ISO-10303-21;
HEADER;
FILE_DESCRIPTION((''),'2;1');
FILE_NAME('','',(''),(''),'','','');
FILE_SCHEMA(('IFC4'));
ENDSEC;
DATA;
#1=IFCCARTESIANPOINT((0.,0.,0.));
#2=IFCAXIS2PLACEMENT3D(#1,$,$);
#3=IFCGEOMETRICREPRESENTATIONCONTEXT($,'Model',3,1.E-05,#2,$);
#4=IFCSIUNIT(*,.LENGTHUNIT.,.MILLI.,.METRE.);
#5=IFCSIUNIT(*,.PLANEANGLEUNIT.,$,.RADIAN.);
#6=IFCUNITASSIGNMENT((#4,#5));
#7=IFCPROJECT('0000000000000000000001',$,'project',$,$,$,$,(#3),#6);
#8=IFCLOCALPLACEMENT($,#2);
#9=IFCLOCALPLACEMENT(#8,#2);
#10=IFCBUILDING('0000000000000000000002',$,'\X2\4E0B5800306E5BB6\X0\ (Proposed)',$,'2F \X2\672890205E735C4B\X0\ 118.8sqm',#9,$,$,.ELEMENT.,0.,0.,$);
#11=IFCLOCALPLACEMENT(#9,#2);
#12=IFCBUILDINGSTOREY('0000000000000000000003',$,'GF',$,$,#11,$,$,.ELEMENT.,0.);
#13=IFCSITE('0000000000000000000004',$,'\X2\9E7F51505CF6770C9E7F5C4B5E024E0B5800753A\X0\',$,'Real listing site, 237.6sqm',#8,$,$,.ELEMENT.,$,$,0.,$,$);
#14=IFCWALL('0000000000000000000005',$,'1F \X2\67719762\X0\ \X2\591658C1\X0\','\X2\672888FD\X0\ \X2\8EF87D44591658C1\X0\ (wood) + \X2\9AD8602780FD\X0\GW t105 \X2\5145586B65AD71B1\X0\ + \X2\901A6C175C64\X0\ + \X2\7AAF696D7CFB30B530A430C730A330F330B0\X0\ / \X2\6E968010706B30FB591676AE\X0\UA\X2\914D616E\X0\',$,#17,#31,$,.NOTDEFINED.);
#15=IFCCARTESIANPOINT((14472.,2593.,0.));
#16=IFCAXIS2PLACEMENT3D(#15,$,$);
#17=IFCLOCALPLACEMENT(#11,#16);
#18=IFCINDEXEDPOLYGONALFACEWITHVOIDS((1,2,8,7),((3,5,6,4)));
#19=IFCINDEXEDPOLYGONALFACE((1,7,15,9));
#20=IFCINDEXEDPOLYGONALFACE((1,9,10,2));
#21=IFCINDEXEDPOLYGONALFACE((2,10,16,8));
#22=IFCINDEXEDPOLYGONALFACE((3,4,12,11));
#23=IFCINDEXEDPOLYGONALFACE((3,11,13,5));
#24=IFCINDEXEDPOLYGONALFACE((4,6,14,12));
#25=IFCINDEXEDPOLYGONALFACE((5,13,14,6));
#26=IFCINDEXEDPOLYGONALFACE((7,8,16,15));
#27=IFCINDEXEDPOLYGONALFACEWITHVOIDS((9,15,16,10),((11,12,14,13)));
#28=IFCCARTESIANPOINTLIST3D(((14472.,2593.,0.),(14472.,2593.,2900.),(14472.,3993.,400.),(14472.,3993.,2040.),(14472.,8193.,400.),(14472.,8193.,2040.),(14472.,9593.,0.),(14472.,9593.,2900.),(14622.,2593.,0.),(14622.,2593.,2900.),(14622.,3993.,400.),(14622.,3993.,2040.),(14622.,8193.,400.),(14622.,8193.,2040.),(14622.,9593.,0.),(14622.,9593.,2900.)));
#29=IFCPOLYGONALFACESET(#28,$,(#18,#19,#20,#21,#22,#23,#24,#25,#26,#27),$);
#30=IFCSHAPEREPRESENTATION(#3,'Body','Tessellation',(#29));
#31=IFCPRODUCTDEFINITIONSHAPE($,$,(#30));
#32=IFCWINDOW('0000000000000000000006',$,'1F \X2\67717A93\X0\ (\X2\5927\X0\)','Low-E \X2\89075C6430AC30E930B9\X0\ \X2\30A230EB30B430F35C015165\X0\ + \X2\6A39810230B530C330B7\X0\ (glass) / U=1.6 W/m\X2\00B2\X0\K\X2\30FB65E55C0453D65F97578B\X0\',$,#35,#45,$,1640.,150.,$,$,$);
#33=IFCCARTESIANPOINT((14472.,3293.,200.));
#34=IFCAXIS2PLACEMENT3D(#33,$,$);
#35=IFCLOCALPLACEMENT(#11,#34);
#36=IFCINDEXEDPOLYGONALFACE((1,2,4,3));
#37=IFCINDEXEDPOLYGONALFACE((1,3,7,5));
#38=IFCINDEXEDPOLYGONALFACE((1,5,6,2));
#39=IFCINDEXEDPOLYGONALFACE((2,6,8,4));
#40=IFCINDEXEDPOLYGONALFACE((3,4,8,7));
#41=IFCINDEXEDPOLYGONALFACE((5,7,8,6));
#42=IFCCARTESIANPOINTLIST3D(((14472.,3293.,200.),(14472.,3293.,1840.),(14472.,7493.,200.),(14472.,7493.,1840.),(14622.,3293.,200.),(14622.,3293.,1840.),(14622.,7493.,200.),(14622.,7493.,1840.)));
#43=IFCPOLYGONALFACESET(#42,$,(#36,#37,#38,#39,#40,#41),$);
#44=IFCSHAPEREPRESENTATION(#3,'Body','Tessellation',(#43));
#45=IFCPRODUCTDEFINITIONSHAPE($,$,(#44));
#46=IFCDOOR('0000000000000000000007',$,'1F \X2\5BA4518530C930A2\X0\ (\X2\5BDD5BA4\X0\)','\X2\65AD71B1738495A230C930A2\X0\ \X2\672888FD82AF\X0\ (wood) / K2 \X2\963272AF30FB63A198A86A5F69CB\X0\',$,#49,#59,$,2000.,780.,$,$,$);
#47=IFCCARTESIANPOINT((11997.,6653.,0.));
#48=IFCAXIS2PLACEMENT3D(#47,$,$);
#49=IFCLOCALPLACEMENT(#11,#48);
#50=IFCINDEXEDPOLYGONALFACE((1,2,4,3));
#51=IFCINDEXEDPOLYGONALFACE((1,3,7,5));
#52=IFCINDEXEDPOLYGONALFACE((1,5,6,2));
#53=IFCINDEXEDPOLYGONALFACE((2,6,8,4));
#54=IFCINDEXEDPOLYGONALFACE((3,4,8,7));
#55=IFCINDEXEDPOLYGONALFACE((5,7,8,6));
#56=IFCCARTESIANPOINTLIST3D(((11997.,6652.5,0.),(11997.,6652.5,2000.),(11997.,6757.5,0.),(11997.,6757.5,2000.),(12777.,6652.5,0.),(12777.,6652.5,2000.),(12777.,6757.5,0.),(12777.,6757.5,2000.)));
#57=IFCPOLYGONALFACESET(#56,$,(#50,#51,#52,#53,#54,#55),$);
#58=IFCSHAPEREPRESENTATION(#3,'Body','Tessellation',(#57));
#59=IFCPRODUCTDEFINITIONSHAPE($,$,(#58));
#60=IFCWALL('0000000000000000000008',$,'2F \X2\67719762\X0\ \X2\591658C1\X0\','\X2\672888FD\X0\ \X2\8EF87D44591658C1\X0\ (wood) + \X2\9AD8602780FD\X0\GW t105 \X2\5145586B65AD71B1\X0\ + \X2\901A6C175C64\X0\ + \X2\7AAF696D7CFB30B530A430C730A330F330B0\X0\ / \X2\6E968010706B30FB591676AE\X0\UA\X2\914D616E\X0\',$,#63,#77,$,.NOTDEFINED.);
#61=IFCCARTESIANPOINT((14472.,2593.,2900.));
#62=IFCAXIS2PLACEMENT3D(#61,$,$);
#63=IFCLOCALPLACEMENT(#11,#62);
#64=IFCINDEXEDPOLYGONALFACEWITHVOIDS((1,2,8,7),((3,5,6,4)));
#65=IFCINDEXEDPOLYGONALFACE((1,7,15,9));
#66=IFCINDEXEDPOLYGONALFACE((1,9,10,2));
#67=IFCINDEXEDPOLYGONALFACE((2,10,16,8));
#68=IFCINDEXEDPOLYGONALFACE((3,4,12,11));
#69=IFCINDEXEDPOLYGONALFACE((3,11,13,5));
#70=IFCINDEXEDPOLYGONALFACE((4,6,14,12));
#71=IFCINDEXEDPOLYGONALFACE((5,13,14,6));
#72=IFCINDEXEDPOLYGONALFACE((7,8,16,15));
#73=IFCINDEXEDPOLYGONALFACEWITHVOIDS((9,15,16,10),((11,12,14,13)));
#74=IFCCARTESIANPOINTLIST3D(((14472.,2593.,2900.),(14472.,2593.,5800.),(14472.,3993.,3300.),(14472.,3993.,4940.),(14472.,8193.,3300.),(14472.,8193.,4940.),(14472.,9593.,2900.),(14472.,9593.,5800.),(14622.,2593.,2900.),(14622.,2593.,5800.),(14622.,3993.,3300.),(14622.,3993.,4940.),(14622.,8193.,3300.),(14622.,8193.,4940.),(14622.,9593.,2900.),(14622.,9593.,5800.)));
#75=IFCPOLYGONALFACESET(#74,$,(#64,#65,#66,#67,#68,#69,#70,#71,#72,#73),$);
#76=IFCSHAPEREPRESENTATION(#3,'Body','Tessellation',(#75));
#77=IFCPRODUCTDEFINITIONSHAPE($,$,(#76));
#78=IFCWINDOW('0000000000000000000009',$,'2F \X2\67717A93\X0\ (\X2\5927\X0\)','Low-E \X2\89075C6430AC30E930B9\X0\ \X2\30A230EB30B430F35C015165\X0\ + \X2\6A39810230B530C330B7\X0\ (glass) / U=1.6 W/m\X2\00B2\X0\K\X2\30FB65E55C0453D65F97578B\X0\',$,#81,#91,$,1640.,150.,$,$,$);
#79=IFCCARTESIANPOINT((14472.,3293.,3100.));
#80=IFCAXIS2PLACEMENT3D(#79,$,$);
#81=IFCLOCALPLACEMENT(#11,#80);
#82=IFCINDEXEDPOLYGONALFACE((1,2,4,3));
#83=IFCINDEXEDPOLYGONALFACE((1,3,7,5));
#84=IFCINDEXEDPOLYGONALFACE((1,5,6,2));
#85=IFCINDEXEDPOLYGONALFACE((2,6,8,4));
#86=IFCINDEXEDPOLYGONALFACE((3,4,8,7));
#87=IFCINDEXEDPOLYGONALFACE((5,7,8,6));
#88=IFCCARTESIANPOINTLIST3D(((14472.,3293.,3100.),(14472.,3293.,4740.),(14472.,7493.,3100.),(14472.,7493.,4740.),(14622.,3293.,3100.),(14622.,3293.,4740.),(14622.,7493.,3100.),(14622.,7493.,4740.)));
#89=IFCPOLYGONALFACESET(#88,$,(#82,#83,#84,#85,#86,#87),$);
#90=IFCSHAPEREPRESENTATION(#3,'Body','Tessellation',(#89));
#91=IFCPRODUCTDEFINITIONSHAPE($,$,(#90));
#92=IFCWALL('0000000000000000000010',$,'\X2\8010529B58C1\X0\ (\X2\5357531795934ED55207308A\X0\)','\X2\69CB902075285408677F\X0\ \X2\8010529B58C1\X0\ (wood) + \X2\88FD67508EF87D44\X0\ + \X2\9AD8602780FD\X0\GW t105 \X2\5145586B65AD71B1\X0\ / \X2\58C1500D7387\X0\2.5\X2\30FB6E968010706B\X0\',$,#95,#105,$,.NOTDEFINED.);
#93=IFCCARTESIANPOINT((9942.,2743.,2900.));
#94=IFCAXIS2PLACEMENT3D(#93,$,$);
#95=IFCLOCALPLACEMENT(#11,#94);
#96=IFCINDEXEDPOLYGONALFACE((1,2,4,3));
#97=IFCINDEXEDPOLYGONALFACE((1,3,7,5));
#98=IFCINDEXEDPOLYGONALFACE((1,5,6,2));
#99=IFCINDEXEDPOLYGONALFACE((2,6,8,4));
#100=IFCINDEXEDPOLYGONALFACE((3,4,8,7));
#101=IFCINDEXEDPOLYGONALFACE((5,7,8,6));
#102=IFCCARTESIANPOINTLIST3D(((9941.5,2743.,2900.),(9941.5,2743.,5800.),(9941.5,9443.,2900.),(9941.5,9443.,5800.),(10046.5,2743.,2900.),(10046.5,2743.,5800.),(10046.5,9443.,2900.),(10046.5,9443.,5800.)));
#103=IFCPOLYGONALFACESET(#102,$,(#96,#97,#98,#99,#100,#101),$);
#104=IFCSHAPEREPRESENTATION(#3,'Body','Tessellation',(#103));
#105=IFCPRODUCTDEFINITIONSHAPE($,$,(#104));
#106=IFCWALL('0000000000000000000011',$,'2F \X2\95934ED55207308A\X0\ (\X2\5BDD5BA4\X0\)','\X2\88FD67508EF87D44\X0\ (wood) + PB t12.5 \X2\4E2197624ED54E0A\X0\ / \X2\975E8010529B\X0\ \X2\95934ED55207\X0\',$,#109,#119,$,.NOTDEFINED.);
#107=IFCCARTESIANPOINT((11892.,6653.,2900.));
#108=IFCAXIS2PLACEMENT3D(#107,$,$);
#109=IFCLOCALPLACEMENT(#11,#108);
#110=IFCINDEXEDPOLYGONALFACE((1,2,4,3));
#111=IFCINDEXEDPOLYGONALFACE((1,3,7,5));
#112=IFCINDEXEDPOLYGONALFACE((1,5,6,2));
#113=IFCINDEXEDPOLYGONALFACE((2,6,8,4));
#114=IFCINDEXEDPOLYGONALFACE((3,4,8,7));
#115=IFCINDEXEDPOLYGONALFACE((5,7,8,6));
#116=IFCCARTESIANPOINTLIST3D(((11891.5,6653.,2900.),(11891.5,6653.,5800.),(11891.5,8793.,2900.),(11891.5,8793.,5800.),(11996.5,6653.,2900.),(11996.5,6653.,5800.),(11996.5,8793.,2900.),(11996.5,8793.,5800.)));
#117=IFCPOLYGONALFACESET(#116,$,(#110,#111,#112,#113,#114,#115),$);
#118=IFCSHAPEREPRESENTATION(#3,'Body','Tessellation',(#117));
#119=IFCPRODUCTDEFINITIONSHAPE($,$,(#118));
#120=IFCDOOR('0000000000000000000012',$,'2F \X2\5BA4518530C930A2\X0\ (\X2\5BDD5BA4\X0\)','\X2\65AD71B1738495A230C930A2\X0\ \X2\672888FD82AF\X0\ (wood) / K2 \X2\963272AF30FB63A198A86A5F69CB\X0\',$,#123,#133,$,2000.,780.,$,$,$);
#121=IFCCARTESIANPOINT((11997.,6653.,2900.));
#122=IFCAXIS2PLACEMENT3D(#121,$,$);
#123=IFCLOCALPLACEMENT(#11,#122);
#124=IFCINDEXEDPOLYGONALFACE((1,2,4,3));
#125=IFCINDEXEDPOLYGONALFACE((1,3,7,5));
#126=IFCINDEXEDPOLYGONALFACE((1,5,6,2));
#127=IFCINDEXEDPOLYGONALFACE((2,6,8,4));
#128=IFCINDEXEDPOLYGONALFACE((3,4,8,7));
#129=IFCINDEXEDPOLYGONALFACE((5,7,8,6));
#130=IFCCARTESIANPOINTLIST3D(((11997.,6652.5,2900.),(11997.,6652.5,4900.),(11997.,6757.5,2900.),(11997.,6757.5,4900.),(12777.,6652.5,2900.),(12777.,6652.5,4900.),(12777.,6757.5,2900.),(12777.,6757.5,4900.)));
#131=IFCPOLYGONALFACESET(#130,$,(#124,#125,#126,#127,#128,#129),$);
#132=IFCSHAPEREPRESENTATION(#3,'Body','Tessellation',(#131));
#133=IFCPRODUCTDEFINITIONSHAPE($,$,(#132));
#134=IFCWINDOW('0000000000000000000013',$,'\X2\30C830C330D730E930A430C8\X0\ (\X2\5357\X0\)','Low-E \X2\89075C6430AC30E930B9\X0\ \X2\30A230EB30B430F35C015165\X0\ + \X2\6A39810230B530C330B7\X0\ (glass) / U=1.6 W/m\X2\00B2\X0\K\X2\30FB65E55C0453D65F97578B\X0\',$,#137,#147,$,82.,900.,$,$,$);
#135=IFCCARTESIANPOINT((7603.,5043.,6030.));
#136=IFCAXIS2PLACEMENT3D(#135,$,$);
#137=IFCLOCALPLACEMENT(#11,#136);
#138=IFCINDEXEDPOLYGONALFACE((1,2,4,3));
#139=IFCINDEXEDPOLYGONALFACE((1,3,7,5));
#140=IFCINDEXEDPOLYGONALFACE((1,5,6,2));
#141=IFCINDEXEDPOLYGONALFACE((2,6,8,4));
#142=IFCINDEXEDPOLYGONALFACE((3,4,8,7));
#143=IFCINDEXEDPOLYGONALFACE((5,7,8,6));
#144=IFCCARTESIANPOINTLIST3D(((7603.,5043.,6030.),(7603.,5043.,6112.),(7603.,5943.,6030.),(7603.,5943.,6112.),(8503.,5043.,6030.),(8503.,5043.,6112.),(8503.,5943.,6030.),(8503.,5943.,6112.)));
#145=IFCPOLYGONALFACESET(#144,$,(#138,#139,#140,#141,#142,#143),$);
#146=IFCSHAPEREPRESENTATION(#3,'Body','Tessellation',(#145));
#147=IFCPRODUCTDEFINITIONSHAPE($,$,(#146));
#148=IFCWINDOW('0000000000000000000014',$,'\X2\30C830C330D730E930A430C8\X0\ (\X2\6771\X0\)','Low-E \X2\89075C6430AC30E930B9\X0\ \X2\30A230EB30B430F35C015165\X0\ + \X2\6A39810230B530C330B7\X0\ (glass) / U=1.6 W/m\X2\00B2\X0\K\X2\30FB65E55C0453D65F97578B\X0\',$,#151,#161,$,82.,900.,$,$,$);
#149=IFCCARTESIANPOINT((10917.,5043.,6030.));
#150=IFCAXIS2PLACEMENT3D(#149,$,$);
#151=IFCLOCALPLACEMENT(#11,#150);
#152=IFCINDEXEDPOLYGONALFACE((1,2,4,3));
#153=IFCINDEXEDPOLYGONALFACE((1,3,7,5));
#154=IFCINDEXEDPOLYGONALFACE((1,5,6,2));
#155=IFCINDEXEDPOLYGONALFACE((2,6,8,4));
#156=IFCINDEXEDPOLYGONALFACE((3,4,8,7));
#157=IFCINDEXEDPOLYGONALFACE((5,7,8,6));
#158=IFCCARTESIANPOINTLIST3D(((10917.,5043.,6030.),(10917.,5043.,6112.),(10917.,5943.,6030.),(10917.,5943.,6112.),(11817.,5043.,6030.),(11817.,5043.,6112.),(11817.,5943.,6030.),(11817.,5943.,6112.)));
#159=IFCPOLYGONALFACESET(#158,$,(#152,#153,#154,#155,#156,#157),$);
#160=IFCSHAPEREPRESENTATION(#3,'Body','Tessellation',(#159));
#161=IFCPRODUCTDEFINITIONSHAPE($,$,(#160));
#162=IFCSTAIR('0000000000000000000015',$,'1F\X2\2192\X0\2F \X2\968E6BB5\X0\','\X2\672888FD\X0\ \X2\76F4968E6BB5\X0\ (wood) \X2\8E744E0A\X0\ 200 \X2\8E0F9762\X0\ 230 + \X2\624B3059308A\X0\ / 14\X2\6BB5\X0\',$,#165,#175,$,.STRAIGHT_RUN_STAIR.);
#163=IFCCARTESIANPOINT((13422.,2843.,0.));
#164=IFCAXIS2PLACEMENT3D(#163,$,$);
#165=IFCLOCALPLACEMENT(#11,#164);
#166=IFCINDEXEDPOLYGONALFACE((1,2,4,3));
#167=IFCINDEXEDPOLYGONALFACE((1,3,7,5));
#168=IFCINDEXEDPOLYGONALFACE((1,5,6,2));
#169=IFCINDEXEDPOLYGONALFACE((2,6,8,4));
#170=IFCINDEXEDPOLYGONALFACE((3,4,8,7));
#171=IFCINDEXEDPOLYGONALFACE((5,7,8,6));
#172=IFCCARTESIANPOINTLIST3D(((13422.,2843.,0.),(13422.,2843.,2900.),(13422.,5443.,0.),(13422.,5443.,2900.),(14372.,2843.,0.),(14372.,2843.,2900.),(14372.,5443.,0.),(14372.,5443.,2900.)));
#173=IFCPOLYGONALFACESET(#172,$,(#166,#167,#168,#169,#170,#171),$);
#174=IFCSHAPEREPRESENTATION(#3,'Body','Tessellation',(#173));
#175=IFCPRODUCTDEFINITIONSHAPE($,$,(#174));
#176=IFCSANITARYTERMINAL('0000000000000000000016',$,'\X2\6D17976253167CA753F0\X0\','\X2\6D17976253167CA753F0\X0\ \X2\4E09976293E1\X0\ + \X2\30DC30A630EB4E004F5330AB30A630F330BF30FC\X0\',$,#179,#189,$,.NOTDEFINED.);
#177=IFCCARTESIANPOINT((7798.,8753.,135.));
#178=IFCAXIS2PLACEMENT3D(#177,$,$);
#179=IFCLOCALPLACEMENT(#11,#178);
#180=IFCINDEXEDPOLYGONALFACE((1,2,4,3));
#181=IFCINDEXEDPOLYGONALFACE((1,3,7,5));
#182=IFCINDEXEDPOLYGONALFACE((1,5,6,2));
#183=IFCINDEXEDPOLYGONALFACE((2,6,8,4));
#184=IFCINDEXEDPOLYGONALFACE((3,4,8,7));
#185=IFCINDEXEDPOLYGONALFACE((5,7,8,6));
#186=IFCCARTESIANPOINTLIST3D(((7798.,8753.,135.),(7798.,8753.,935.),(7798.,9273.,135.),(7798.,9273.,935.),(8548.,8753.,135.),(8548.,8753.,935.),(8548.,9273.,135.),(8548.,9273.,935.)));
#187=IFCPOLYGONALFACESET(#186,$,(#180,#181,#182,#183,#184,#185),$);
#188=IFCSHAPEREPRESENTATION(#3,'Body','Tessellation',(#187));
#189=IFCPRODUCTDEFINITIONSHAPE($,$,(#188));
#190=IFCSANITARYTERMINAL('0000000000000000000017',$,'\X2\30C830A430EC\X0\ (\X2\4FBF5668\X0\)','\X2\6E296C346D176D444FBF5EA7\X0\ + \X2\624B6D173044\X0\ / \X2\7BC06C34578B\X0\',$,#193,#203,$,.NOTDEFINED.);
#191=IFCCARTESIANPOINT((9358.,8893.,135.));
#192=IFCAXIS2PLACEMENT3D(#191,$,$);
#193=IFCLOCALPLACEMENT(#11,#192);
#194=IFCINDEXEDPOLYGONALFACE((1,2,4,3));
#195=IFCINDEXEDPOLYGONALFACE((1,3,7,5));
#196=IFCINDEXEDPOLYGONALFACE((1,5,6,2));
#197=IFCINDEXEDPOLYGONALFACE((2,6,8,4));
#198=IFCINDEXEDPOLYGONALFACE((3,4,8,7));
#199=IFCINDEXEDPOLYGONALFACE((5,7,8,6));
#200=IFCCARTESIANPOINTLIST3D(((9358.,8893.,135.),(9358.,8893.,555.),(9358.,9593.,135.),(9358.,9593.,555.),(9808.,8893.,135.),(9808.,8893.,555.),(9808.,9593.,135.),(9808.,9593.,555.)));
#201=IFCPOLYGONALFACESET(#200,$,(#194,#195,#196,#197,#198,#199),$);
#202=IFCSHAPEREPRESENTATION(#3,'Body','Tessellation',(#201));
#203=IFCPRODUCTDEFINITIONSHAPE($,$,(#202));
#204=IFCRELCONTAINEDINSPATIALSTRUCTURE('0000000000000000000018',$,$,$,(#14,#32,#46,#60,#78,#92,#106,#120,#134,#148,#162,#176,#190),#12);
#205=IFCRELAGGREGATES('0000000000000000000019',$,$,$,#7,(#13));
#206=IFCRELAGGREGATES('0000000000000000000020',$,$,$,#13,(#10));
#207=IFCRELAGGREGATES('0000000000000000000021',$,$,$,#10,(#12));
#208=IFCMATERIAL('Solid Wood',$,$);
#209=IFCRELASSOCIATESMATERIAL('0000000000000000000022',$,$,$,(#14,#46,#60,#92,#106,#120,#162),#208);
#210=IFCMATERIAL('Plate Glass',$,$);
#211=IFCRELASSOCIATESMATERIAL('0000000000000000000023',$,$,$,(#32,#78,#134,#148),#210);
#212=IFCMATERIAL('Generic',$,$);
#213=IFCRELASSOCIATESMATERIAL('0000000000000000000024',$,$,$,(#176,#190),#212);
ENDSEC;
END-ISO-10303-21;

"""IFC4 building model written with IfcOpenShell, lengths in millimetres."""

from ifc_helpers import new_model, si_unit, frame, frame_2d, origin, place, context, project, spatial, rectangle, extrude, material, element, fill, save


model = new_model("IFC4")

# Units and contexts
model_context = context("Model", 3, precision=1e-05, world=origin())
ifc_project = project(units=[si_unit("LENGTHUNIT", "METRE", prefix="MILLI"), si_unit("PLANEANGLEUNIT", "RADIAN")], contexts=[model_context])

# Site, building, storey
site_placement = place(None, origin())
site = spatial("IfcSite", under=ifc_project, at=site_placement, Name="鹿児島県鹿屋市下堀町", ObjectType="Real listing site, 237.6sqm", CompositionType="ELEMENT", RefElevation=0.0)
building_placement = place(site_placement, origin())
building = spatial("IfcBuilding", under=site, at=building_placement, Name="下堀の家 (Proposed)", ObjectType="2F 木造平屋 118.8sqm", CompositionType="ELEMENT", ElevationOfRefHeight=0.0, ElevationOfTerrain=0.0)
storey_placement = place(building_placement, origin())
storey = spatial("IfcBuildingStorey", under=building, at=storey_placement, Name="GF", CompositionType="ELEMENT", Elevation=0.0)

# Wall, opening, window
ifc_material_1 = material(Name="Solid Wood")
wall_1_placement = place(storey_placement, frame((14472.0, 2593.0, 0.0)))
wall_1 = element("IfcWall", 1, at=wall_1_placement, inside=storey, material=ifc_material_1, Name="1F 東面 外壁", Description="木製 軸組外壁 (wood) + 高性能GW t105 充填断熱 + 通気層 + 窯業系サイディング / 準耐火・外皮UA配慮", PredefinedType="NOTDEFINED", context=model_context, shape_type="SweptSolid", body=[
    extrude(rectangle(XDim=150.0, YDim=7000.0, at=frame_2d((75.0, 3500.0))), frame((14472.0, 2593.0, 0.0)), (0.0, 0.0, 1.0), 2900.0),
])
opening_1_placement = place(storey_placement, frame((14472.0, 3293.0, 200.0)))
opening_1 = element("IfcOpeningElement", 2, at=opening_1_placement, cuts=wall_1, PredefinedType="NOTDEFINED", context=model_context, shape_type="SweptSolid", body=[
    extrude(rectangle(XDim=150.0, YDim=4200.0, at=frame_2d((75.0, 2100.0))), frame((14472.0, 3293.0, 200.0)), (0.0, 0.0, 1.0), 1640.0),
])
ifc_material_2 = material(Name="Plate Glass")
window_1_placement = place(storey_placement, frame((14472.0, 3293.0, 200.0)))
window_1 = element("IfcWindow", 3, at=window_1_placement, inside=storey, material=ifc_material_2, Name="1F 東窓 (大)", Description="Low-E 複層ガラス アルゴン封入 + 樹脂サッシ (glass) / U=1.6 W/m²K・日射取得型", OverallHeight=1640.0, OverallWidth=150.0, context=model_context, shape_type="SweptSolid", body=[
    extrude(rectangle(XDim=150.0, YDim=4200.0, at=frame_2d((75.0, 2100.0))), frame((14472.0, 3293.0, 200.0)), (0.0, 0.0, 1.0), 1640.0),
])
fill(opening_1, window_1)

# Door
door_1_placement = place(storey_placement, frame((11997.0, 6653.0, 0.0)))
element("IfcDoor", 4, at=door_1_placement, inside=storey, material=ifc_material_1, Name="1F 室内ドア (寝室)", Description="断熱玄関ドア 木製芯 (wood) / K2 防犯・採風機構", OverallHeight=2000.0, OverallWidth=780.0, context=model_context, shape_type="SweptSolid", body=[
    extrude(rectangle(XDim=780.0, YDim=105.0, at=frame_2d((390.0, 52.0))), frame((11997.0, 6653.0, 0.0)), (0.0, 0.0, 1.0), 2000.0),
])

# Wall, opening, window
wall_2_placement = place(storey_placement, frame((14472.0, 2593.0, 2900.0)))
wall_2 = element("IfcWall", 5, at=wall_2_placement, inside=storey, material=ifc_material_1, Name="2F 東面 外壁", Description="木製 軸組外壁 (wood) + 高性能GW t105 充填断熱 + 通気層 + 窯業系サイディング / 準耐火・外皮UA配慮", PredefinedType="NOTDEFINED", context=model_context, shape_type="SweptSolid", body=[
    extrude(rectangle(XDim=150.0, YDim=7000.0, at=frame_2d((75.0, 3500.0))), frame((14472.0, 2593.0, 2900.0)), (0.0, 0.0, 1.0), 2900.0),
])
opening_2_placement = place(storey_placement, frame((14472.0, 3293.0, 3100.0)))
opening_2 = element("IfcOpeningElement", 6, at=opening_2_placement, cuts=wall_2, PredefinedType="NOTDEFINED", context=model_context, shape_type="SweptSolid", body=[
    extrude(rectangle(XDim=150.0, YDim=4200.0, at=frame_2d((75.0, 2100.0))), frame((14472.0, 3293.0, 3100.0)), (0.0, 0.0, 1.0), 1640.0),
])
window_2_placement = place(storey_placement, frame((14472.0, 3293.0, 3100.0)))
window_2 = element("IfcWindow", 7, at=window_2_placement, inside=storey, material=ifc_material_2, Name="2F 東窓 (大)", Description="Low-E 複層ガラス アルゴン封入 + 樹脂サッシ (glass) / U=1.6 W/m²K・日射取得型", OverallHeight=1640.0, OverallWidth=150.0, context=model_context, shape_type="SweptSolid", body=[
    extrude(rectangle(XDim=150.0, YDim=4200.0, at=frame_2d((75.0, 2100.0))), frame((14472.0, 3293.0, 3100.0)), (0.0, 0.0, 1.0), 1640.0),
])
fill(opening_2, window_2)

# Walls
wall_3_placement = place(storey_placement, frame((9942.0, 2743.0, 2900.0)))
element("IfcWall", 8, at=wall_3_placement, inside=storey, material=ifc_material_1, Name="耐力壁 (南北間仕切り)", Description="構造用合板 耐力壁 (wood) + 製材軸組 + 高性能GW t105 充填断熱 / 壁倍率2.5・準耐火", PredefinedType="NOTDEFINED", context=model_context, shape_type="SweptSolid", body=[
    extrude(rectangle(XDim=105.0, YDim=6700.0, at=frame_2d((52.0, 3350.0))), frame((9942.0, 2743.0, 2900.0)), (0.0, 0.0, 1.0), 2900.0),
])
wall_4_placement = place(storey_placement, frame((11892.0, 6653.0, 2900.0)))
element("IfcWall", 9, at=wall_4_placement, inside=storey, material=ifc_material_1, Name="2F 間仕切り (寝室)", Description="製材軸組 (wood) + PB t12.5 両面仕上 / 非耐力 間仕切", PredefinedType="NOTDEFINED", context=model_context, shape_type="SweptSolid", body=[
    extrude(rectangle(XDim=105.0, YDim=2140.0, at=frame_2d((52.0, 1070.0))), frame((11892.0, 6653.0, 2900.0)), (0.0, 0.0, 1.0), 2900.0),
])

# Door
door_2_placement = place(storey_placement, frame((11997.0, 6653.0, 2900.0)))
element("IfcDoor", 10, at=door_2_placement, inside=storey, material=ifc_material_1, Name="2F 室内ドア (寝室)", Description="断熱玄関ドア 木製芯 (wood) / K2 防犯・採風機構", OverallHeight=2000.0, OverallWidth=780.0, context=model_context, shape_type="SweptSolid", body=[
    extrude(rectangle(XDim=780.0, YDim=105.0, at=frame_2d((390.0, 52.0))), frame((11997.0, 6653.0, 2900.0)), (0.0, 0.0, 1.0), 2000.0),
])

# Windows
window_3_placement = place(storey_placement, frame((7603.0, 5043.0, 6030.0)))
element("IfcWindow", 11, at=window_3_placement, inside=storey, material=ifc_material_2, Name="トップライト (南)", Description="Low-E 複層ガラス アルゴン封入 + 樹脂サッシ (glass) / U=1.6 W/m²K・日射取得型", OverallHeight=82.0, OverallWidth=900.0, context=model_context, shape_type="SweptSolid", body=[
    extrude(rectangle(XDim=900.0, YDim=900.0, at=frame_2d((450.0, 450.0))), frame((7603.0, 5043.0, 6030.0)), (0.0, 0.0, 1.0), 82.0),
])
window_4_placement = place(storey_placement, frame((10917.0, 5043.0, 6030.0)))
element("IfcWindow", 12, at=window_4_placement, inside=storey, material=ifc_material_2, Name="トップライト (東)", Description="Low-E 複層ガラス アルゴン封入 + 樹脂サッシ (glass) / U=1.6 W/m²K・日射取得型", OverallHeight=82.0, OverallWidth=900.0, context=model_context, shape_type="SweptSolid", body=[
    extrude(rectangle(XDim=900.0, YDim=900.0, at=frame_2d((450.0, 450.0))), frame((10917.0, 5043.0, 6030.0)), (0.0, 0.0, 1.0), 82.0),
])

# Stair
stair_placement = place(storey_placement, frame((13422.0, 2843.0, 0.0)))
element("IfcStair", 13, at=stair_placement, inside=storey, material=ifc_material_1, Name="1F→2F 階段", Description="木製 直階段 (wood) 蹴上 200 踏面 230 + 手すり / 14段", PredefinedType="STRAIGHT_RUN_STAIR", context=model_context, shape_type="SweptSolid", body=[
    extrude(rectangle(XDim=950.0, YDim=2600.0, at=frame_2d((475.0, 1300.0))), frame((13422.0, 2843.0, 0.0)), (0.0, 0.0, 1.0), 2900.0),
])

# Sanitary terminals
ifc_material_3 = material(Name="Generic")
sanitary_terminal_1_placement = place(storey_placement, frame((7798.0, 8753.0, 135.0)))
element("IfcSanitaryTerminal", 14, at=sanitary_terminal_1_placement, inside=storey, material=ifc_material_3, Name="洗面化粧台", Description="洗面化粧台 三面鏡 + ボウル一体カウンター", PredefinedType="NOTDEFINED", context=model_context, shape_type="SweptSolid", body=[
    extrude(rectangle(XDim=750.0, YDim=520.0, at=frame_2d((375.0, 260.0))), frame((7798.0, 8753.0, 135.0)), (0.0, 0.0, 1.0), 800.0),
])
sanitary_terminal_2_placement = place(storey_placement, frame((9358.0, 8893.0, 135.0)))
element("IfcSanitaryTerminal", 15, at=sanitary_terminal_2_placement, inside=storey, material=ifc_material_3, Name="トイレ (便器)", Description="温水洗浄便座 + 手洗い / 節水型", PredefinedType="NOTDEFINED", context=model_context, shape_type="SweptSolid", body=[
    extrude(rectangle(XDim=450.0, YDim=700.0, at=frame_2d((225.0, 350.0))), frame((9358.0, 8893.0, 135.0)), (0.0, 0.0, 1.0), 420.0),
])

save(model, "model.ifc")
